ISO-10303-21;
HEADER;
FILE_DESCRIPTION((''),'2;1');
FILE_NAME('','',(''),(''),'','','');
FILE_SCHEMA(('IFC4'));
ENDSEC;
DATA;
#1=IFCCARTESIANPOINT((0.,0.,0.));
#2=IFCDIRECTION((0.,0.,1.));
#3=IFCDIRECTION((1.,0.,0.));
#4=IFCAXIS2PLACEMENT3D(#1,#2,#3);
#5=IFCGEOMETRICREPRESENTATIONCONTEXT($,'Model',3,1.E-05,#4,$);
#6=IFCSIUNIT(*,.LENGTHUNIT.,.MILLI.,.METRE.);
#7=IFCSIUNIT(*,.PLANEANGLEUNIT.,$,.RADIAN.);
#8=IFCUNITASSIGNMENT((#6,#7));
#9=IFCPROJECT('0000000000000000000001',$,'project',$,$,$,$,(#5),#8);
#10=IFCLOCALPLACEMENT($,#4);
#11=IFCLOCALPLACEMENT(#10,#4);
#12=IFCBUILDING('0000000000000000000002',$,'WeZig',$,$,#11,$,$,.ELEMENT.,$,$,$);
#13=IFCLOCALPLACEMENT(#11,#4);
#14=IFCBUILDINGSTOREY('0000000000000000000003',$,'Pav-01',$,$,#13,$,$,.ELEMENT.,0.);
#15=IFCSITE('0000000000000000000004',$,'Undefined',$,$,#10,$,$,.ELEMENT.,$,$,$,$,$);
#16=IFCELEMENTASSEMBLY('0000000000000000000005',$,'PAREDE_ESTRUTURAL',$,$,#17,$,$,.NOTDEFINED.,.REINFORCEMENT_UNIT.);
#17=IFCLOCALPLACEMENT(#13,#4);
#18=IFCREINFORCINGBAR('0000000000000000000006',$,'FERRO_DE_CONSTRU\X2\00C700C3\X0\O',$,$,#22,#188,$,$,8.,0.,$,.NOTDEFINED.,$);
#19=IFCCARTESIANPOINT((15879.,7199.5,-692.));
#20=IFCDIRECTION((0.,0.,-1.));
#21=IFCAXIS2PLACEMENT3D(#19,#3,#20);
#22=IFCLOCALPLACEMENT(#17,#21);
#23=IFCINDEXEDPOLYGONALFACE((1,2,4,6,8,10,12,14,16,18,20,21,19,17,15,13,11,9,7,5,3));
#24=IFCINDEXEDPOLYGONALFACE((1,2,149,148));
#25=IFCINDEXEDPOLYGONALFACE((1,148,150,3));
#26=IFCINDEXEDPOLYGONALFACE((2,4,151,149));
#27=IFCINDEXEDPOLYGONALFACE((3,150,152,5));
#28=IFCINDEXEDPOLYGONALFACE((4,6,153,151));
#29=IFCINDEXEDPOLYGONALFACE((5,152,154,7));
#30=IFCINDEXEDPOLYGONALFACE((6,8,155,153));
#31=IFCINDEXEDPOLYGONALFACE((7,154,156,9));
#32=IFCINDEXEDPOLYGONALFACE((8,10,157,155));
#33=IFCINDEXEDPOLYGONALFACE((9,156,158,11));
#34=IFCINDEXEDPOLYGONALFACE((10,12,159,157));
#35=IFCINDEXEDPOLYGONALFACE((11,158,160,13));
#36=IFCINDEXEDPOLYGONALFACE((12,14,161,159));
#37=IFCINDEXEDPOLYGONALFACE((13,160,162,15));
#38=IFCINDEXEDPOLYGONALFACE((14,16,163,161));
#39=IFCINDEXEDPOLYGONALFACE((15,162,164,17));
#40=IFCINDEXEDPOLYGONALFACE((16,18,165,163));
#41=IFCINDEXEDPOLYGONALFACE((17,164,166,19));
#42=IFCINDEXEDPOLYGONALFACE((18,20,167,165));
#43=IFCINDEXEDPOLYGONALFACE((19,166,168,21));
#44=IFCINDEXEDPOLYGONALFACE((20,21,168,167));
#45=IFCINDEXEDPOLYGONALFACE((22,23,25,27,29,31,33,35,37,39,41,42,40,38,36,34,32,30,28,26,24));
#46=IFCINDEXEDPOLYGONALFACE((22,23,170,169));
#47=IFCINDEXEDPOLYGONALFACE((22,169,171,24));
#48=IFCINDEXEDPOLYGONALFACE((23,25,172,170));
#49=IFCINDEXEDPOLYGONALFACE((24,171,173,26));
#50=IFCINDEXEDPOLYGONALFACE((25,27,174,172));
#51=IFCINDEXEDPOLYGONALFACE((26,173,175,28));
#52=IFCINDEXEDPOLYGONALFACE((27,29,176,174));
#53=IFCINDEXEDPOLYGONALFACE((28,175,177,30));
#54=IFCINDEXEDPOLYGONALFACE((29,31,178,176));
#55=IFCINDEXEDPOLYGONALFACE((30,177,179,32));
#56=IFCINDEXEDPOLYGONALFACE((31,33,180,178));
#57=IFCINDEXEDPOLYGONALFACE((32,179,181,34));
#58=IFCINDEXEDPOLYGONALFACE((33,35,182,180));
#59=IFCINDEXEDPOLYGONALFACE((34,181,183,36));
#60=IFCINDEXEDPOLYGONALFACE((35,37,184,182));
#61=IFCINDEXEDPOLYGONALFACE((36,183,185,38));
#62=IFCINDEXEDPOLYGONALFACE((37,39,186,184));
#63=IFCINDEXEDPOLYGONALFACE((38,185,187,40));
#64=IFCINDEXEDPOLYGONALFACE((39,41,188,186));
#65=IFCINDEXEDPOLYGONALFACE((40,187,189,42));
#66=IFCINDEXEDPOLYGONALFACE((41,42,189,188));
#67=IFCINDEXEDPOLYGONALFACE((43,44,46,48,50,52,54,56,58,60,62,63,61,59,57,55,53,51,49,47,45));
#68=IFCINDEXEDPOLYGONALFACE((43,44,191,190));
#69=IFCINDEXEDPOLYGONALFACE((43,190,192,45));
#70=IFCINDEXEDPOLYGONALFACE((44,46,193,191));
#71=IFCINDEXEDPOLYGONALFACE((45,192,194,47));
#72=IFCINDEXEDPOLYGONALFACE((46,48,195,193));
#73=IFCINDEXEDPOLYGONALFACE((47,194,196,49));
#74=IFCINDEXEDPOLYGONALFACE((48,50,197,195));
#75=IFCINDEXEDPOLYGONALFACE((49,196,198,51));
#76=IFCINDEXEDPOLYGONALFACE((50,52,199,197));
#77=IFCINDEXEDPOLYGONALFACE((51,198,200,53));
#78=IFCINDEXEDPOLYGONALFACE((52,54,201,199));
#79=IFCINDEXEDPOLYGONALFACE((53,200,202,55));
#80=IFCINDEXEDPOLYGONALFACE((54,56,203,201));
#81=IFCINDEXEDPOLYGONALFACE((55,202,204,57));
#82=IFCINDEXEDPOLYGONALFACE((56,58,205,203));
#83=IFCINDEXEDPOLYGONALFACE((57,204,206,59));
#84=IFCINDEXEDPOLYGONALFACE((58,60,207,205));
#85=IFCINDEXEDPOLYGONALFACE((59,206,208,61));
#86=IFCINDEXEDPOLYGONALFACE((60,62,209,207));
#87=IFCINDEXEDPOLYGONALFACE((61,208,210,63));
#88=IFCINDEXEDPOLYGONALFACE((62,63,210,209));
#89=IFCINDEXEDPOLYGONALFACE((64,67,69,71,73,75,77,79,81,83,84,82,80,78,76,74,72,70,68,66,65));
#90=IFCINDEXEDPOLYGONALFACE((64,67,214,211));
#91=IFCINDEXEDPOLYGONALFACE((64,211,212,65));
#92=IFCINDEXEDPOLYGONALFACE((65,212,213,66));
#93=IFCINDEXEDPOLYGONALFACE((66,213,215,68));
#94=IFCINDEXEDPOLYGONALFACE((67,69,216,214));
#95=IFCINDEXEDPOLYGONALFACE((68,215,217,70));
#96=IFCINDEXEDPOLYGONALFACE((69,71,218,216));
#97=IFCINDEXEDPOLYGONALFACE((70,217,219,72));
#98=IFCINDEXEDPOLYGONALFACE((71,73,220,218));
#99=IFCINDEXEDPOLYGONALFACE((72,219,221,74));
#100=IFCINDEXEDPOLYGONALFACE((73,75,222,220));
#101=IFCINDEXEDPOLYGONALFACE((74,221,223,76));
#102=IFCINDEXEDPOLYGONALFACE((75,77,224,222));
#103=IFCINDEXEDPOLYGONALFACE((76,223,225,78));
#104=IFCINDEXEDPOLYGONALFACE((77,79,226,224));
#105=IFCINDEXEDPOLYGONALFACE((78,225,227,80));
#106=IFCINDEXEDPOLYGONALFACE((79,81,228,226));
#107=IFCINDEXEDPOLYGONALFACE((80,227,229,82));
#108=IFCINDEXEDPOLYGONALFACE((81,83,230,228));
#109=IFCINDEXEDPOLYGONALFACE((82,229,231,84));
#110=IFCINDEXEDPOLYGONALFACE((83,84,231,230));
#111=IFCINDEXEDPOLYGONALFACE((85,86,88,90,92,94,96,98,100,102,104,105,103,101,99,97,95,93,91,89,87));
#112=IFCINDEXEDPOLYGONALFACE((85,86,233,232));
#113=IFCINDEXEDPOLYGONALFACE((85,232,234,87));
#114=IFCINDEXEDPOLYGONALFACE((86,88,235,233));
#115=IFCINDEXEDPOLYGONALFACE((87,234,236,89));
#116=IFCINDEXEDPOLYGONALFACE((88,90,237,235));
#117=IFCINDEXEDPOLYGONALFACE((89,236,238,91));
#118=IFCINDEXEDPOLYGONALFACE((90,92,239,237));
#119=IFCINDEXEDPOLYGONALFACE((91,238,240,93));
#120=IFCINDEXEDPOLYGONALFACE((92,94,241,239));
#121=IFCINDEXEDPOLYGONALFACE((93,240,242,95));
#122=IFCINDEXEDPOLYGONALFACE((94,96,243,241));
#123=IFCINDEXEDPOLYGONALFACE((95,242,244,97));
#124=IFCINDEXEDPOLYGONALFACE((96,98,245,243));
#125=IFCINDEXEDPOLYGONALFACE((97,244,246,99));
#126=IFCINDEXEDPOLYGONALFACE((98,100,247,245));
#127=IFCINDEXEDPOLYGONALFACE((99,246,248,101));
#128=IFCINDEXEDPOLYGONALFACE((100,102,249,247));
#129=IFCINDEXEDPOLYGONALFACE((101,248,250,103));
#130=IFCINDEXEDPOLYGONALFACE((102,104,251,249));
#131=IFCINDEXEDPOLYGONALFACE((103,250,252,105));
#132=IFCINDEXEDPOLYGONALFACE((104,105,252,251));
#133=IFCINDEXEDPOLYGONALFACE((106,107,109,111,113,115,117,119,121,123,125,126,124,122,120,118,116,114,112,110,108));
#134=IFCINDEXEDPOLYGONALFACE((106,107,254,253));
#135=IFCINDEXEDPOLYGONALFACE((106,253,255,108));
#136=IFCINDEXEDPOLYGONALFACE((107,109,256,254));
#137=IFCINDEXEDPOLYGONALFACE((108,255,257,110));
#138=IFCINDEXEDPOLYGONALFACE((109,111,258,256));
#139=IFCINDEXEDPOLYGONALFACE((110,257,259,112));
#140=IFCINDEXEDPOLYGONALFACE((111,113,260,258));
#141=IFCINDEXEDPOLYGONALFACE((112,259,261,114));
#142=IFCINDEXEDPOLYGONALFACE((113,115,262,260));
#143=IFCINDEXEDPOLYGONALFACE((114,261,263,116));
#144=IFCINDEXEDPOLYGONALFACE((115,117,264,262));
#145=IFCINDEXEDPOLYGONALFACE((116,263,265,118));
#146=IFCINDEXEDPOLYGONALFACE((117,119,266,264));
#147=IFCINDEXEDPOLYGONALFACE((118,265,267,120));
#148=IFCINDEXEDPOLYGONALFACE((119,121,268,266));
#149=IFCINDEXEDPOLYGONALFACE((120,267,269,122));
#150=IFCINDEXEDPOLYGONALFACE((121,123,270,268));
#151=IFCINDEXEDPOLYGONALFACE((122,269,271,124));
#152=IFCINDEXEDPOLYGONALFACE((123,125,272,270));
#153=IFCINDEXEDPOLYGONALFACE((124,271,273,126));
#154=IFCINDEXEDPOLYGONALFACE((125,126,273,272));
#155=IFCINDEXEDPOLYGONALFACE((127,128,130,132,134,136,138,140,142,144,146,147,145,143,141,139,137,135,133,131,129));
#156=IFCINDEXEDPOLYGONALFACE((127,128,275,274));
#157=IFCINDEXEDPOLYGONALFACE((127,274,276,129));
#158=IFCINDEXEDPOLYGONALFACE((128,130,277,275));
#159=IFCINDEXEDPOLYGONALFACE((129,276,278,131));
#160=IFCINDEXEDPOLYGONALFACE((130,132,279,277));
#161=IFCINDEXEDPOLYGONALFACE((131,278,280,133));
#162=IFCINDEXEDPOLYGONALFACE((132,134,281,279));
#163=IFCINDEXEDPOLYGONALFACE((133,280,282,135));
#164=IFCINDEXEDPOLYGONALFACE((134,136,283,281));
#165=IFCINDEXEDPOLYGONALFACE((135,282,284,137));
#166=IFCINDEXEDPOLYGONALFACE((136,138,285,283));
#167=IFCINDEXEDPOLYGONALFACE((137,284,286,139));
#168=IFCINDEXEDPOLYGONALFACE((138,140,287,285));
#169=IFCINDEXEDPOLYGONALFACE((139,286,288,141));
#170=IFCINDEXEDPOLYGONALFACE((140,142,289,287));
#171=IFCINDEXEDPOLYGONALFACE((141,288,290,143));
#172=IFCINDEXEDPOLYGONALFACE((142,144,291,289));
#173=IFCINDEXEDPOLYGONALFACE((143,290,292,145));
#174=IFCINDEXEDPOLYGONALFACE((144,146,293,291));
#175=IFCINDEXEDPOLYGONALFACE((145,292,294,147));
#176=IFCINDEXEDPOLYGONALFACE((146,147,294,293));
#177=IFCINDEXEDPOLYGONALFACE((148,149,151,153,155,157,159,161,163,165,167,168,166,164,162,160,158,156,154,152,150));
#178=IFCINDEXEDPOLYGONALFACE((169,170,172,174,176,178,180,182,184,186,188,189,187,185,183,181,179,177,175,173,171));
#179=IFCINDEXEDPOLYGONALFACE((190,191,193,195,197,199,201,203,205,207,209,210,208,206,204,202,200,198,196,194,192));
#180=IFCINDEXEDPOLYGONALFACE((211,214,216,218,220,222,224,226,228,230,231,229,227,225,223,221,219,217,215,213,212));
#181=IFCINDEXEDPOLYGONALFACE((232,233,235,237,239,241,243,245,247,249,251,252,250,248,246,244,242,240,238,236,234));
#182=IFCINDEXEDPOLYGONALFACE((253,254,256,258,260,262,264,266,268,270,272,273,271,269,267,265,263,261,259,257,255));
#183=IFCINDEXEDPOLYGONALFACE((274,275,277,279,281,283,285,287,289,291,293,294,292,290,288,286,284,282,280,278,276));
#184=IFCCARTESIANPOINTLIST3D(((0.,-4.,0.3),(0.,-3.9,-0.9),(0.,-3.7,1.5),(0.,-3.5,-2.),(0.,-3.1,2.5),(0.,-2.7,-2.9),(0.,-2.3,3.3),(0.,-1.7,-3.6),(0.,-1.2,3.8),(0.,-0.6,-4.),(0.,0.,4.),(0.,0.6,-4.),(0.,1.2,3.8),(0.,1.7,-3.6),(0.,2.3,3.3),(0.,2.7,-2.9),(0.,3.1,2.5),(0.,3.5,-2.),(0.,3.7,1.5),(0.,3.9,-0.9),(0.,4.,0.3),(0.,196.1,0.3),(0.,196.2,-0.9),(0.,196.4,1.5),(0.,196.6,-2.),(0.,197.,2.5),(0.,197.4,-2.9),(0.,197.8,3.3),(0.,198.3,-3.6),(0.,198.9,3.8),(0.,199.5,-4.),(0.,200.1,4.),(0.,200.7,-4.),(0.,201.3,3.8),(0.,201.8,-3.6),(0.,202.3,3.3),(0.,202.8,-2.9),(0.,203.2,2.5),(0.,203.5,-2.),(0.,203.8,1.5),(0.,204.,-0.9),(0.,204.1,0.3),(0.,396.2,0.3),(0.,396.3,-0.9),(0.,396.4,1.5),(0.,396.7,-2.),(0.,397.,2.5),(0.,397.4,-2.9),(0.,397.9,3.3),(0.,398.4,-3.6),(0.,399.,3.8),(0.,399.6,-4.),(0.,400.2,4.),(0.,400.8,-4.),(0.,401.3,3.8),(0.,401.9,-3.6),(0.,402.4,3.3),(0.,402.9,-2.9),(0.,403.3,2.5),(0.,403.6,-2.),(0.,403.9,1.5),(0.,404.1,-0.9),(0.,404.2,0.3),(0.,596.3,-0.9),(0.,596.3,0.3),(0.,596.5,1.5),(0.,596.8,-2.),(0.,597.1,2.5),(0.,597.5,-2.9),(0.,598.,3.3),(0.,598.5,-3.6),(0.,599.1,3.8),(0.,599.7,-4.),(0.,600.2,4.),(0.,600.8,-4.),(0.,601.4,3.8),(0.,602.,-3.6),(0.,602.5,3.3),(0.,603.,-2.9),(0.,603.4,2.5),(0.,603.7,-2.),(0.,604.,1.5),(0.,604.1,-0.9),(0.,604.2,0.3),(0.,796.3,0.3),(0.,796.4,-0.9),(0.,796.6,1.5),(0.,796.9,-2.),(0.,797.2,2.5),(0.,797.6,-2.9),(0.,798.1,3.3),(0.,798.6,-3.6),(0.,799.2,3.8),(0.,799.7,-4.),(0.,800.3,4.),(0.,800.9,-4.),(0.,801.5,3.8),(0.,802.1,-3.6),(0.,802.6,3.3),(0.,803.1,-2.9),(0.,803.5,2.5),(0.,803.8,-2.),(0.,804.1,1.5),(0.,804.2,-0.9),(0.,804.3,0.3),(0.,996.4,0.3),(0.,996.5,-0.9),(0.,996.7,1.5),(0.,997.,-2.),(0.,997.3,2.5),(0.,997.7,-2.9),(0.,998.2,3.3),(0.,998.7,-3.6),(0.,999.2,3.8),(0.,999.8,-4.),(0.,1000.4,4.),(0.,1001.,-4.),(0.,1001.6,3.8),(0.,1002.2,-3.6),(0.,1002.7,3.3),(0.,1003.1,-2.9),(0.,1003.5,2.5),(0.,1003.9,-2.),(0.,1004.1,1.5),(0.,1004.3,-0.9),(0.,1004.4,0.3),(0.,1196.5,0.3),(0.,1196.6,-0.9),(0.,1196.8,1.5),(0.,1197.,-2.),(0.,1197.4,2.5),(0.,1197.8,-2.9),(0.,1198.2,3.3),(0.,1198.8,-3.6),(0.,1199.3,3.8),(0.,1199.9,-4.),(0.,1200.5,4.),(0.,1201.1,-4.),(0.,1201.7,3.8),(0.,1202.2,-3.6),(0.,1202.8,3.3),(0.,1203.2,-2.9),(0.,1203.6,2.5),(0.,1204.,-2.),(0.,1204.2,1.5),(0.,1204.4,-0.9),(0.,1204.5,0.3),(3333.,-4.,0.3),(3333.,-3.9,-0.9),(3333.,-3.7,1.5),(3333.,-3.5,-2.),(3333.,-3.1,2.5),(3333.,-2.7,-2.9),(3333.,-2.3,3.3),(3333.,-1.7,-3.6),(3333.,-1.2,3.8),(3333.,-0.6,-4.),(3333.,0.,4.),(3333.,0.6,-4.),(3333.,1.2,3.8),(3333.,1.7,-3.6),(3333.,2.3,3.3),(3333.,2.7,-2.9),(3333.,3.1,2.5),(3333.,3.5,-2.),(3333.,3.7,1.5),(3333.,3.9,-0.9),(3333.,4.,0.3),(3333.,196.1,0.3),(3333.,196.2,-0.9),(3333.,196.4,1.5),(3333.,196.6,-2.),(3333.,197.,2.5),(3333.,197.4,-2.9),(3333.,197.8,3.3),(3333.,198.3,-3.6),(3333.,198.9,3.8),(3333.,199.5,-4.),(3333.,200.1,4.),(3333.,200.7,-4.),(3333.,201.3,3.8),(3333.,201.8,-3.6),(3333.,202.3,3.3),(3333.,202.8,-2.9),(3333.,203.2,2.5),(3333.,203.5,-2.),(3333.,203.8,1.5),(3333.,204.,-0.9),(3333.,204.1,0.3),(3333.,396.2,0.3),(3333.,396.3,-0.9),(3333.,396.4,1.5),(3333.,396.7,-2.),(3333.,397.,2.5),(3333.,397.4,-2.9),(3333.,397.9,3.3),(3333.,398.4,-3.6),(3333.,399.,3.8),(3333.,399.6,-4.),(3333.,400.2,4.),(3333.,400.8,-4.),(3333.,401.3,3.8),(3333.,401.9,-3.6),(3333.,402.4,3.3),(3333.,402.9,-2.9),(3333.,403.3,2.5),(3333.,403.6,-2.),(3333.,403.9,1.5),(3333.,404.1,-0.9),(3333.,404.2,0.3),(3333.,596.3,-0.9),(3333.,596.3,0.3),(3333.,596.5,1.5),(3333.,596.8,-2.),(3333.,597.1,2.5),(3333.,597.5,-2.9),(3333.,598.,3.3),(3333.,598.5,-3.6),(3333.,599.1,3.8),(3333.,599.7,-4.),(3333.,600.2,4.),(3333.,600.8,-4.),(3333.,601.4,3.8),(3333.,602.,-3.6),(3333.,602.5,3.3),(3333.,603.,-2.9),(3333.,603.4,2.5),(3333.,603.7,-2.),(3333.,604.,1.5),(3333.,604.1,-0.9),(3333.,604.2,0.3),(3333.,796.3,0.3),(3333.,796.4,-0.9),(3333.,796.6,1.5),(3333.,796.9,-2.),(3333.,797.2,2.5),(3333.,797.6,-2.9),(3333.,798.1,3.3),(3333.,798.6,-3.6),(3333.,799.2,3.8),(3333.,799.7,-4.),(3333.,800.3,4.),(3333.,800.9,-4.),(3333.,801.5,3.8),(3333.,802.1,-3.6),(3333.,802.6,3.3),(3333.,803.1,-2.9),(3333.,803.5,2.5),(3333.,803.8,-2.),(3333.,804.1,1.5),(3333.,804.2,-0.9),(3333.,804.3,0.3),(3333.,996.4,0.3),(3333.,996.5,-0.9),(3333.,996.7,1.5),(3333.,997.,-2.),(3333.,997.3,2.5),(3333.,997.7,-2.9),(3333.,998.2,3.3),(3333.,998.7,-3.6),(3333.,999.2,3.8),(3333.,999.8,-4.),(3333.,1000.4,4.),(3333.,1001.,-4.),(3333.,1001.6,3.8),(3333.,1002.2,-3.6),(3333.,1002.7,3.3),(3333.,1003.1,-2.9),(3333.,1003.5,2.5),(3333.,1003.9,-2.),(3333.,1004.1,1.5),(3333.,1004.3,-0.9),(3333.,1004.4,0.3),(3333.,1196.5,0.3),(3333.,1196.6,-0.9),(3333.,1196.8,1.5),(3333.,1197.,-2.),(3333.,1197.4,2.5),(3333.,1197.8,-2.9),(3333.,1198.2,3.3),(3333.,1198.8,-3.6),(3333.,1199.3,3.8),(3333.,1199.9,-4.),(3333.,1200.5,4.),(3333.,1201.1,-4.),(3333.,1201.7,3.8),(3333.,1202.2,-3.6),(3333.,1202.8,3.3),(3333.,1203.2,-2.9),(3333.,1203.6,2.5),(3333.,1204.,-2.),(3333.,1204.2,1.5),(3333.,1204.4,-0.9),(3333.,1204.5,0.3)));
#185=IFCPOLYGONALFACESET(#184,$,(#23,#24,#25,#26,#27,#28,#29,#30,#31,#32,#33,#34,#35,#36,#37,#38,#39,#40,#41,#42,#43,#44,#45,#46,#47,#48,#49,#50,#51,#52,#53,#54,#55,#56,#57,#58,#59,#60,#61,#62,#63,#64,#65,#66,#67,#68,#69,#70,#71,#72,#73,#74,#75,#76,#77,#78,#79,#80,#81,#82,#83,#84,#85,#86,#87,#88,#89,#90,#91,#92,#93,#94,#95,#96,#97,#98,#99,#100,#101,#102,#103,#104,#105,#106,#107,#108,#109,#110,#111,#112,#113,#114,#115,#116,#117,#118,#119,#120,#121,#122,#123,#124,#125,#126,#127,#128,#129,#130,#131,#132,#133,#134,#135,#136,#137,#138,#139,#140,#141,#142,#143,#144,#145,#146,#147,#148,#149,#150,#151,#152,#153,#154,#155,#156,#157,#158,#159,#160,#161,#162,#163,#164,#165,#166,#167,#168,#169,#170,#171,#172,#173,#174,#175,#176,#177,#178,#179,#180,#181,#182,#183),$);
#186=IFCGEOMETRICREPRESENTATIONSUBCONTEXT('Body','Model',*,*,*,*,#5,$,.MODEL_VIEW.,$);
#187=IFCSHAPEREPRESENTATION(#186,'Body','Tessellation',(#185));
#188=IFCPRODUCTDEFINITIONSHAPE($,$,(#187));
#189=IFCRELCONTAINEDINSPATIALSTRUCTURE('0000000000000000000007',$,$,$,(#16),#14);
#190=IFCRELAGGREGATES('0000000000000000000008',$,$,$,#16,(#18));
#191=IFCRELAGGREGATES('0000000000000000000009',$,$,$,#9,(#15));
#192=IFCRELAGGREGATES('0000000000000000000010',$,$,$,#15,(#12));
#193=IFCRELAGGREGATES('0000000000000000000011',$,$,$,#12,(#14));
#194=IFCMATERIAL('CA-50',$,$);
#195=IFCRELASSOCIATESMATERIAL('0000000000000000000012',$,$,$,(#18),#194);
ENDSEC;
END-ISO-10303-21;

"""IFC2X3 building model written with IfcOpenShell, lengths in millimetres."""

from ifc_helpers import new_model, entity, si_unit, frame, origin_with_axes, place, context, subcontext, project, spatial, source, transform, mapped, material, element, aggregate, save


model = new_model("IFC2X3")

# Units and contexts
model_context = context("Model", 3, precision=1e-05, world=origin_with_axes())
body_context = subcontext(model_context, "Body", "Model", "MODEL_VIEW")
ifc_project = project(units=[si_unit("LENGTHUNIT", "METRE", prefix="MILLI"), si_unit("PLANEANGLEUNIT", "RADIAN")], contexts=[model_context])

# Site, building, storey
site_placement = place(None, origin_with_axes())
site = spatial("IfcSite", under=ifc_project, at=site_placement, Name="Undefined", CompositionType="ELEMENT")
building_placement = place(site_placement, origin_with_axes())
building = spatial("IfcBuilding", under=site, at=building_placement, Name="WeZig", CompositionType="ELEMENT")
storey_placement = place(building_placement, origin_with_axes())
storey = spatial("IfcBuildingStorey", under=building, at=storey_placement, Name="Pav-01", CompositionType="ELEMENT", Elevation=0.0)

# Shared definitions
ifc_material_1 = material(Name="CA-50")

# Element assembly, reinforcing bar
assembly_1_placement = place(storey_placement, origin_with_axes())
assembly_1 = element("IfcElementAssembly", 1, at=assembly_1_placement, inside=storey, Name="PAREDE_ESTRUTURAL", AssemblyPlace="NOTDEFINED", PredefinedType="REINFORCEMENT_UNIT")
shared_shape_1 = source(origin_with_axes(), body_context, "Body", "AdvancedSweptSolid", [
    entity("IfcSweptDiskSolid", entity("IfcTrimmedCurve", entity("IfcLine", entity("IfcCartesianPoint", [0.0, 0.0, 0.0]), entity("IfcVector", entity("IfcDirection", [1.0, 0.0, 0.0]), 1.0)), [entity("IfcParameterValue", 0.0)], [entity("IfcParameterValue", 3333.0)], True, "PARAMETER"), 4.0, None, 0.0, 3333.0),
])
shared_shape_2 = source(origin_with_axes(), body_context, "Body", "AdvancedSweptSolid", [
    entity("IfcSweptDiskSolid", entity("IfcTrimmedCurve", entity("IfcLine", entity("IfcCartesianPoint", [0.0, 0.0, 0.0]), entity("IfcVector", entity("IfcDirection", [1.0, 0.0, 0.0]), 1.0)), [entity("IfcParameterValue", 0.0)], [entity("IfcParameterValue", 3333.0)], True, "PARAMETER"), 4.0, None, 0.0, 3333.0),
])
shared_shape_3 = source(origin_with_axes(), body_context, "Body", "AdvancedSweptSolid", [
    entity("IfcSweptDiskSolid", entity("IfcTrimmedCurve", entity("IfcLine", entity("IfcCartesianPoint", [0.0, 0.0, 0.0]), entity("IfcVector", entity("IfcDirection", [1.0, 0.0, 0.0]), 1.0)), [entity("IfcParameterValue", 0.0)], [entity("IfcParameterValue", 3333.0)], True, "PARAMETER"), 4.0, None, 0.0, 3333.0),
])
shared_shape_4 = source(origin_with_axes(), body_context, "Body", "AdvancedSweptSolid", [
    entity("IfcSweptDiskSolid", entity("IfcTrimmedCurve", entity("IfcLine", entity("IfcCartesianPoint", [0.0, 0.0, 0.0]), entity("IfcVector", entity("IfcDirection", [1.0, 0.0, 0.0]), 1.0)), [entity("IfcParameterValue", 0.0)], [entity("IfcParameterValue", 3333.0)], True, "PARAMETER"), 4.0, None, 0.0, 3333.0),
])
shared_shape_5 = source(origin_with_axes(), body_context, "Body", "AdvancedSweptSolid", [
    entity("IfcSweptDiskSolid", entity("IfcTrimmedCurve", entity("IfcLine", entity("IfcCartesianPoint", [0.0, 0.0, 0.0]), entity("IfcVector", entity("IfcDirection", [1.0, 0.0, 0.0]), 1.0)), [entity("IfcParameterValue", 0.0)], [entity("IfcParameterValue", 3333.0)], True, "PARAMETER"), 4.0, None, 0.0, 3333.0),
])
shared_shape_6 = source(origin_with_axes(), body_context, "Body", "AdvancedSweptSolid", [
    entity("IfcSweptDiskSolid", entity("IfcTrimmedCurve", entity("IfcLine", entity("IfcCartesianPoint", [0.0, 0.0, 0.0]), entity("IfcVector", entity("IfcDirection", [1.0, 0.0, 0.0]), 1.0)), [entity("IfcParameterValue", 0.0)], [entity("IfcParameterValue", 3333.0)], True, "PARAMETER"), 4.0, None, 0.0, 3333.0),
])
shared_shape_7 = source(origin_with_axes(), body_context, "Body", "AdvancedSweptSolid", [
    entity("IfcSweptDiskSolid", entity("IfcTrimmedCurve", entity("IfcLine", entity("IfcCartesianPoint", [0.0, 0.0, 0.0]), entity("IfcVector", entity("IfcDirection", [1.0, 0.0, 0.0]), 1.0)), [entity("IfcParameterValue", 0.0)], [entity("IfcParameterValue", 3333.0)], True, "PARAMETER"), 4.0, None, 0.0, 3333.0),
])
reinforcing_bar_1_placement = place(assembly_1_placement, frame((15879.0, 7199.5, -692.0), z_axis=(1.0, 0.0, 0.0), x_axis=(0.0, 0.0, -1.0)))
reinforcing_bar_1 = element("IfcReinforcingBar", 2, at=reinforcing_bar_1_placement, material=ifc_material_1, Name="FERRO_DE_CONSTRUÇÃO", BarRole="NOTDEFINED", CrossSectionArea=0.0, NominalDiameter=8.0, context=body_context, shape_type="MappedRepresentation", body=[
    mapped(shared_shape_1, transform((0.0, 0.0, 0.0))),
    mapped(shared_shape_2, transform((0.0, 200.1, 0.0))),
    mapped(shared_shape_3, transform((0.0, 400.2, 0.0))),
    mapped(shared_shape_4, transform((0.0, 600.2, 0.0))),
    mapped(shared_shape_5, transform((0.0, 800.3, 0.0))),
    mapped(shared_shape_6, transform((0.0, 1000.4, 0.0))),
    mapped(shared_shape_7, transform((0.0, 1200.5, 0.0))),
])
aggregate(assembly_1, [reinforcing_bar_1])

save(model, "model.ifc")
